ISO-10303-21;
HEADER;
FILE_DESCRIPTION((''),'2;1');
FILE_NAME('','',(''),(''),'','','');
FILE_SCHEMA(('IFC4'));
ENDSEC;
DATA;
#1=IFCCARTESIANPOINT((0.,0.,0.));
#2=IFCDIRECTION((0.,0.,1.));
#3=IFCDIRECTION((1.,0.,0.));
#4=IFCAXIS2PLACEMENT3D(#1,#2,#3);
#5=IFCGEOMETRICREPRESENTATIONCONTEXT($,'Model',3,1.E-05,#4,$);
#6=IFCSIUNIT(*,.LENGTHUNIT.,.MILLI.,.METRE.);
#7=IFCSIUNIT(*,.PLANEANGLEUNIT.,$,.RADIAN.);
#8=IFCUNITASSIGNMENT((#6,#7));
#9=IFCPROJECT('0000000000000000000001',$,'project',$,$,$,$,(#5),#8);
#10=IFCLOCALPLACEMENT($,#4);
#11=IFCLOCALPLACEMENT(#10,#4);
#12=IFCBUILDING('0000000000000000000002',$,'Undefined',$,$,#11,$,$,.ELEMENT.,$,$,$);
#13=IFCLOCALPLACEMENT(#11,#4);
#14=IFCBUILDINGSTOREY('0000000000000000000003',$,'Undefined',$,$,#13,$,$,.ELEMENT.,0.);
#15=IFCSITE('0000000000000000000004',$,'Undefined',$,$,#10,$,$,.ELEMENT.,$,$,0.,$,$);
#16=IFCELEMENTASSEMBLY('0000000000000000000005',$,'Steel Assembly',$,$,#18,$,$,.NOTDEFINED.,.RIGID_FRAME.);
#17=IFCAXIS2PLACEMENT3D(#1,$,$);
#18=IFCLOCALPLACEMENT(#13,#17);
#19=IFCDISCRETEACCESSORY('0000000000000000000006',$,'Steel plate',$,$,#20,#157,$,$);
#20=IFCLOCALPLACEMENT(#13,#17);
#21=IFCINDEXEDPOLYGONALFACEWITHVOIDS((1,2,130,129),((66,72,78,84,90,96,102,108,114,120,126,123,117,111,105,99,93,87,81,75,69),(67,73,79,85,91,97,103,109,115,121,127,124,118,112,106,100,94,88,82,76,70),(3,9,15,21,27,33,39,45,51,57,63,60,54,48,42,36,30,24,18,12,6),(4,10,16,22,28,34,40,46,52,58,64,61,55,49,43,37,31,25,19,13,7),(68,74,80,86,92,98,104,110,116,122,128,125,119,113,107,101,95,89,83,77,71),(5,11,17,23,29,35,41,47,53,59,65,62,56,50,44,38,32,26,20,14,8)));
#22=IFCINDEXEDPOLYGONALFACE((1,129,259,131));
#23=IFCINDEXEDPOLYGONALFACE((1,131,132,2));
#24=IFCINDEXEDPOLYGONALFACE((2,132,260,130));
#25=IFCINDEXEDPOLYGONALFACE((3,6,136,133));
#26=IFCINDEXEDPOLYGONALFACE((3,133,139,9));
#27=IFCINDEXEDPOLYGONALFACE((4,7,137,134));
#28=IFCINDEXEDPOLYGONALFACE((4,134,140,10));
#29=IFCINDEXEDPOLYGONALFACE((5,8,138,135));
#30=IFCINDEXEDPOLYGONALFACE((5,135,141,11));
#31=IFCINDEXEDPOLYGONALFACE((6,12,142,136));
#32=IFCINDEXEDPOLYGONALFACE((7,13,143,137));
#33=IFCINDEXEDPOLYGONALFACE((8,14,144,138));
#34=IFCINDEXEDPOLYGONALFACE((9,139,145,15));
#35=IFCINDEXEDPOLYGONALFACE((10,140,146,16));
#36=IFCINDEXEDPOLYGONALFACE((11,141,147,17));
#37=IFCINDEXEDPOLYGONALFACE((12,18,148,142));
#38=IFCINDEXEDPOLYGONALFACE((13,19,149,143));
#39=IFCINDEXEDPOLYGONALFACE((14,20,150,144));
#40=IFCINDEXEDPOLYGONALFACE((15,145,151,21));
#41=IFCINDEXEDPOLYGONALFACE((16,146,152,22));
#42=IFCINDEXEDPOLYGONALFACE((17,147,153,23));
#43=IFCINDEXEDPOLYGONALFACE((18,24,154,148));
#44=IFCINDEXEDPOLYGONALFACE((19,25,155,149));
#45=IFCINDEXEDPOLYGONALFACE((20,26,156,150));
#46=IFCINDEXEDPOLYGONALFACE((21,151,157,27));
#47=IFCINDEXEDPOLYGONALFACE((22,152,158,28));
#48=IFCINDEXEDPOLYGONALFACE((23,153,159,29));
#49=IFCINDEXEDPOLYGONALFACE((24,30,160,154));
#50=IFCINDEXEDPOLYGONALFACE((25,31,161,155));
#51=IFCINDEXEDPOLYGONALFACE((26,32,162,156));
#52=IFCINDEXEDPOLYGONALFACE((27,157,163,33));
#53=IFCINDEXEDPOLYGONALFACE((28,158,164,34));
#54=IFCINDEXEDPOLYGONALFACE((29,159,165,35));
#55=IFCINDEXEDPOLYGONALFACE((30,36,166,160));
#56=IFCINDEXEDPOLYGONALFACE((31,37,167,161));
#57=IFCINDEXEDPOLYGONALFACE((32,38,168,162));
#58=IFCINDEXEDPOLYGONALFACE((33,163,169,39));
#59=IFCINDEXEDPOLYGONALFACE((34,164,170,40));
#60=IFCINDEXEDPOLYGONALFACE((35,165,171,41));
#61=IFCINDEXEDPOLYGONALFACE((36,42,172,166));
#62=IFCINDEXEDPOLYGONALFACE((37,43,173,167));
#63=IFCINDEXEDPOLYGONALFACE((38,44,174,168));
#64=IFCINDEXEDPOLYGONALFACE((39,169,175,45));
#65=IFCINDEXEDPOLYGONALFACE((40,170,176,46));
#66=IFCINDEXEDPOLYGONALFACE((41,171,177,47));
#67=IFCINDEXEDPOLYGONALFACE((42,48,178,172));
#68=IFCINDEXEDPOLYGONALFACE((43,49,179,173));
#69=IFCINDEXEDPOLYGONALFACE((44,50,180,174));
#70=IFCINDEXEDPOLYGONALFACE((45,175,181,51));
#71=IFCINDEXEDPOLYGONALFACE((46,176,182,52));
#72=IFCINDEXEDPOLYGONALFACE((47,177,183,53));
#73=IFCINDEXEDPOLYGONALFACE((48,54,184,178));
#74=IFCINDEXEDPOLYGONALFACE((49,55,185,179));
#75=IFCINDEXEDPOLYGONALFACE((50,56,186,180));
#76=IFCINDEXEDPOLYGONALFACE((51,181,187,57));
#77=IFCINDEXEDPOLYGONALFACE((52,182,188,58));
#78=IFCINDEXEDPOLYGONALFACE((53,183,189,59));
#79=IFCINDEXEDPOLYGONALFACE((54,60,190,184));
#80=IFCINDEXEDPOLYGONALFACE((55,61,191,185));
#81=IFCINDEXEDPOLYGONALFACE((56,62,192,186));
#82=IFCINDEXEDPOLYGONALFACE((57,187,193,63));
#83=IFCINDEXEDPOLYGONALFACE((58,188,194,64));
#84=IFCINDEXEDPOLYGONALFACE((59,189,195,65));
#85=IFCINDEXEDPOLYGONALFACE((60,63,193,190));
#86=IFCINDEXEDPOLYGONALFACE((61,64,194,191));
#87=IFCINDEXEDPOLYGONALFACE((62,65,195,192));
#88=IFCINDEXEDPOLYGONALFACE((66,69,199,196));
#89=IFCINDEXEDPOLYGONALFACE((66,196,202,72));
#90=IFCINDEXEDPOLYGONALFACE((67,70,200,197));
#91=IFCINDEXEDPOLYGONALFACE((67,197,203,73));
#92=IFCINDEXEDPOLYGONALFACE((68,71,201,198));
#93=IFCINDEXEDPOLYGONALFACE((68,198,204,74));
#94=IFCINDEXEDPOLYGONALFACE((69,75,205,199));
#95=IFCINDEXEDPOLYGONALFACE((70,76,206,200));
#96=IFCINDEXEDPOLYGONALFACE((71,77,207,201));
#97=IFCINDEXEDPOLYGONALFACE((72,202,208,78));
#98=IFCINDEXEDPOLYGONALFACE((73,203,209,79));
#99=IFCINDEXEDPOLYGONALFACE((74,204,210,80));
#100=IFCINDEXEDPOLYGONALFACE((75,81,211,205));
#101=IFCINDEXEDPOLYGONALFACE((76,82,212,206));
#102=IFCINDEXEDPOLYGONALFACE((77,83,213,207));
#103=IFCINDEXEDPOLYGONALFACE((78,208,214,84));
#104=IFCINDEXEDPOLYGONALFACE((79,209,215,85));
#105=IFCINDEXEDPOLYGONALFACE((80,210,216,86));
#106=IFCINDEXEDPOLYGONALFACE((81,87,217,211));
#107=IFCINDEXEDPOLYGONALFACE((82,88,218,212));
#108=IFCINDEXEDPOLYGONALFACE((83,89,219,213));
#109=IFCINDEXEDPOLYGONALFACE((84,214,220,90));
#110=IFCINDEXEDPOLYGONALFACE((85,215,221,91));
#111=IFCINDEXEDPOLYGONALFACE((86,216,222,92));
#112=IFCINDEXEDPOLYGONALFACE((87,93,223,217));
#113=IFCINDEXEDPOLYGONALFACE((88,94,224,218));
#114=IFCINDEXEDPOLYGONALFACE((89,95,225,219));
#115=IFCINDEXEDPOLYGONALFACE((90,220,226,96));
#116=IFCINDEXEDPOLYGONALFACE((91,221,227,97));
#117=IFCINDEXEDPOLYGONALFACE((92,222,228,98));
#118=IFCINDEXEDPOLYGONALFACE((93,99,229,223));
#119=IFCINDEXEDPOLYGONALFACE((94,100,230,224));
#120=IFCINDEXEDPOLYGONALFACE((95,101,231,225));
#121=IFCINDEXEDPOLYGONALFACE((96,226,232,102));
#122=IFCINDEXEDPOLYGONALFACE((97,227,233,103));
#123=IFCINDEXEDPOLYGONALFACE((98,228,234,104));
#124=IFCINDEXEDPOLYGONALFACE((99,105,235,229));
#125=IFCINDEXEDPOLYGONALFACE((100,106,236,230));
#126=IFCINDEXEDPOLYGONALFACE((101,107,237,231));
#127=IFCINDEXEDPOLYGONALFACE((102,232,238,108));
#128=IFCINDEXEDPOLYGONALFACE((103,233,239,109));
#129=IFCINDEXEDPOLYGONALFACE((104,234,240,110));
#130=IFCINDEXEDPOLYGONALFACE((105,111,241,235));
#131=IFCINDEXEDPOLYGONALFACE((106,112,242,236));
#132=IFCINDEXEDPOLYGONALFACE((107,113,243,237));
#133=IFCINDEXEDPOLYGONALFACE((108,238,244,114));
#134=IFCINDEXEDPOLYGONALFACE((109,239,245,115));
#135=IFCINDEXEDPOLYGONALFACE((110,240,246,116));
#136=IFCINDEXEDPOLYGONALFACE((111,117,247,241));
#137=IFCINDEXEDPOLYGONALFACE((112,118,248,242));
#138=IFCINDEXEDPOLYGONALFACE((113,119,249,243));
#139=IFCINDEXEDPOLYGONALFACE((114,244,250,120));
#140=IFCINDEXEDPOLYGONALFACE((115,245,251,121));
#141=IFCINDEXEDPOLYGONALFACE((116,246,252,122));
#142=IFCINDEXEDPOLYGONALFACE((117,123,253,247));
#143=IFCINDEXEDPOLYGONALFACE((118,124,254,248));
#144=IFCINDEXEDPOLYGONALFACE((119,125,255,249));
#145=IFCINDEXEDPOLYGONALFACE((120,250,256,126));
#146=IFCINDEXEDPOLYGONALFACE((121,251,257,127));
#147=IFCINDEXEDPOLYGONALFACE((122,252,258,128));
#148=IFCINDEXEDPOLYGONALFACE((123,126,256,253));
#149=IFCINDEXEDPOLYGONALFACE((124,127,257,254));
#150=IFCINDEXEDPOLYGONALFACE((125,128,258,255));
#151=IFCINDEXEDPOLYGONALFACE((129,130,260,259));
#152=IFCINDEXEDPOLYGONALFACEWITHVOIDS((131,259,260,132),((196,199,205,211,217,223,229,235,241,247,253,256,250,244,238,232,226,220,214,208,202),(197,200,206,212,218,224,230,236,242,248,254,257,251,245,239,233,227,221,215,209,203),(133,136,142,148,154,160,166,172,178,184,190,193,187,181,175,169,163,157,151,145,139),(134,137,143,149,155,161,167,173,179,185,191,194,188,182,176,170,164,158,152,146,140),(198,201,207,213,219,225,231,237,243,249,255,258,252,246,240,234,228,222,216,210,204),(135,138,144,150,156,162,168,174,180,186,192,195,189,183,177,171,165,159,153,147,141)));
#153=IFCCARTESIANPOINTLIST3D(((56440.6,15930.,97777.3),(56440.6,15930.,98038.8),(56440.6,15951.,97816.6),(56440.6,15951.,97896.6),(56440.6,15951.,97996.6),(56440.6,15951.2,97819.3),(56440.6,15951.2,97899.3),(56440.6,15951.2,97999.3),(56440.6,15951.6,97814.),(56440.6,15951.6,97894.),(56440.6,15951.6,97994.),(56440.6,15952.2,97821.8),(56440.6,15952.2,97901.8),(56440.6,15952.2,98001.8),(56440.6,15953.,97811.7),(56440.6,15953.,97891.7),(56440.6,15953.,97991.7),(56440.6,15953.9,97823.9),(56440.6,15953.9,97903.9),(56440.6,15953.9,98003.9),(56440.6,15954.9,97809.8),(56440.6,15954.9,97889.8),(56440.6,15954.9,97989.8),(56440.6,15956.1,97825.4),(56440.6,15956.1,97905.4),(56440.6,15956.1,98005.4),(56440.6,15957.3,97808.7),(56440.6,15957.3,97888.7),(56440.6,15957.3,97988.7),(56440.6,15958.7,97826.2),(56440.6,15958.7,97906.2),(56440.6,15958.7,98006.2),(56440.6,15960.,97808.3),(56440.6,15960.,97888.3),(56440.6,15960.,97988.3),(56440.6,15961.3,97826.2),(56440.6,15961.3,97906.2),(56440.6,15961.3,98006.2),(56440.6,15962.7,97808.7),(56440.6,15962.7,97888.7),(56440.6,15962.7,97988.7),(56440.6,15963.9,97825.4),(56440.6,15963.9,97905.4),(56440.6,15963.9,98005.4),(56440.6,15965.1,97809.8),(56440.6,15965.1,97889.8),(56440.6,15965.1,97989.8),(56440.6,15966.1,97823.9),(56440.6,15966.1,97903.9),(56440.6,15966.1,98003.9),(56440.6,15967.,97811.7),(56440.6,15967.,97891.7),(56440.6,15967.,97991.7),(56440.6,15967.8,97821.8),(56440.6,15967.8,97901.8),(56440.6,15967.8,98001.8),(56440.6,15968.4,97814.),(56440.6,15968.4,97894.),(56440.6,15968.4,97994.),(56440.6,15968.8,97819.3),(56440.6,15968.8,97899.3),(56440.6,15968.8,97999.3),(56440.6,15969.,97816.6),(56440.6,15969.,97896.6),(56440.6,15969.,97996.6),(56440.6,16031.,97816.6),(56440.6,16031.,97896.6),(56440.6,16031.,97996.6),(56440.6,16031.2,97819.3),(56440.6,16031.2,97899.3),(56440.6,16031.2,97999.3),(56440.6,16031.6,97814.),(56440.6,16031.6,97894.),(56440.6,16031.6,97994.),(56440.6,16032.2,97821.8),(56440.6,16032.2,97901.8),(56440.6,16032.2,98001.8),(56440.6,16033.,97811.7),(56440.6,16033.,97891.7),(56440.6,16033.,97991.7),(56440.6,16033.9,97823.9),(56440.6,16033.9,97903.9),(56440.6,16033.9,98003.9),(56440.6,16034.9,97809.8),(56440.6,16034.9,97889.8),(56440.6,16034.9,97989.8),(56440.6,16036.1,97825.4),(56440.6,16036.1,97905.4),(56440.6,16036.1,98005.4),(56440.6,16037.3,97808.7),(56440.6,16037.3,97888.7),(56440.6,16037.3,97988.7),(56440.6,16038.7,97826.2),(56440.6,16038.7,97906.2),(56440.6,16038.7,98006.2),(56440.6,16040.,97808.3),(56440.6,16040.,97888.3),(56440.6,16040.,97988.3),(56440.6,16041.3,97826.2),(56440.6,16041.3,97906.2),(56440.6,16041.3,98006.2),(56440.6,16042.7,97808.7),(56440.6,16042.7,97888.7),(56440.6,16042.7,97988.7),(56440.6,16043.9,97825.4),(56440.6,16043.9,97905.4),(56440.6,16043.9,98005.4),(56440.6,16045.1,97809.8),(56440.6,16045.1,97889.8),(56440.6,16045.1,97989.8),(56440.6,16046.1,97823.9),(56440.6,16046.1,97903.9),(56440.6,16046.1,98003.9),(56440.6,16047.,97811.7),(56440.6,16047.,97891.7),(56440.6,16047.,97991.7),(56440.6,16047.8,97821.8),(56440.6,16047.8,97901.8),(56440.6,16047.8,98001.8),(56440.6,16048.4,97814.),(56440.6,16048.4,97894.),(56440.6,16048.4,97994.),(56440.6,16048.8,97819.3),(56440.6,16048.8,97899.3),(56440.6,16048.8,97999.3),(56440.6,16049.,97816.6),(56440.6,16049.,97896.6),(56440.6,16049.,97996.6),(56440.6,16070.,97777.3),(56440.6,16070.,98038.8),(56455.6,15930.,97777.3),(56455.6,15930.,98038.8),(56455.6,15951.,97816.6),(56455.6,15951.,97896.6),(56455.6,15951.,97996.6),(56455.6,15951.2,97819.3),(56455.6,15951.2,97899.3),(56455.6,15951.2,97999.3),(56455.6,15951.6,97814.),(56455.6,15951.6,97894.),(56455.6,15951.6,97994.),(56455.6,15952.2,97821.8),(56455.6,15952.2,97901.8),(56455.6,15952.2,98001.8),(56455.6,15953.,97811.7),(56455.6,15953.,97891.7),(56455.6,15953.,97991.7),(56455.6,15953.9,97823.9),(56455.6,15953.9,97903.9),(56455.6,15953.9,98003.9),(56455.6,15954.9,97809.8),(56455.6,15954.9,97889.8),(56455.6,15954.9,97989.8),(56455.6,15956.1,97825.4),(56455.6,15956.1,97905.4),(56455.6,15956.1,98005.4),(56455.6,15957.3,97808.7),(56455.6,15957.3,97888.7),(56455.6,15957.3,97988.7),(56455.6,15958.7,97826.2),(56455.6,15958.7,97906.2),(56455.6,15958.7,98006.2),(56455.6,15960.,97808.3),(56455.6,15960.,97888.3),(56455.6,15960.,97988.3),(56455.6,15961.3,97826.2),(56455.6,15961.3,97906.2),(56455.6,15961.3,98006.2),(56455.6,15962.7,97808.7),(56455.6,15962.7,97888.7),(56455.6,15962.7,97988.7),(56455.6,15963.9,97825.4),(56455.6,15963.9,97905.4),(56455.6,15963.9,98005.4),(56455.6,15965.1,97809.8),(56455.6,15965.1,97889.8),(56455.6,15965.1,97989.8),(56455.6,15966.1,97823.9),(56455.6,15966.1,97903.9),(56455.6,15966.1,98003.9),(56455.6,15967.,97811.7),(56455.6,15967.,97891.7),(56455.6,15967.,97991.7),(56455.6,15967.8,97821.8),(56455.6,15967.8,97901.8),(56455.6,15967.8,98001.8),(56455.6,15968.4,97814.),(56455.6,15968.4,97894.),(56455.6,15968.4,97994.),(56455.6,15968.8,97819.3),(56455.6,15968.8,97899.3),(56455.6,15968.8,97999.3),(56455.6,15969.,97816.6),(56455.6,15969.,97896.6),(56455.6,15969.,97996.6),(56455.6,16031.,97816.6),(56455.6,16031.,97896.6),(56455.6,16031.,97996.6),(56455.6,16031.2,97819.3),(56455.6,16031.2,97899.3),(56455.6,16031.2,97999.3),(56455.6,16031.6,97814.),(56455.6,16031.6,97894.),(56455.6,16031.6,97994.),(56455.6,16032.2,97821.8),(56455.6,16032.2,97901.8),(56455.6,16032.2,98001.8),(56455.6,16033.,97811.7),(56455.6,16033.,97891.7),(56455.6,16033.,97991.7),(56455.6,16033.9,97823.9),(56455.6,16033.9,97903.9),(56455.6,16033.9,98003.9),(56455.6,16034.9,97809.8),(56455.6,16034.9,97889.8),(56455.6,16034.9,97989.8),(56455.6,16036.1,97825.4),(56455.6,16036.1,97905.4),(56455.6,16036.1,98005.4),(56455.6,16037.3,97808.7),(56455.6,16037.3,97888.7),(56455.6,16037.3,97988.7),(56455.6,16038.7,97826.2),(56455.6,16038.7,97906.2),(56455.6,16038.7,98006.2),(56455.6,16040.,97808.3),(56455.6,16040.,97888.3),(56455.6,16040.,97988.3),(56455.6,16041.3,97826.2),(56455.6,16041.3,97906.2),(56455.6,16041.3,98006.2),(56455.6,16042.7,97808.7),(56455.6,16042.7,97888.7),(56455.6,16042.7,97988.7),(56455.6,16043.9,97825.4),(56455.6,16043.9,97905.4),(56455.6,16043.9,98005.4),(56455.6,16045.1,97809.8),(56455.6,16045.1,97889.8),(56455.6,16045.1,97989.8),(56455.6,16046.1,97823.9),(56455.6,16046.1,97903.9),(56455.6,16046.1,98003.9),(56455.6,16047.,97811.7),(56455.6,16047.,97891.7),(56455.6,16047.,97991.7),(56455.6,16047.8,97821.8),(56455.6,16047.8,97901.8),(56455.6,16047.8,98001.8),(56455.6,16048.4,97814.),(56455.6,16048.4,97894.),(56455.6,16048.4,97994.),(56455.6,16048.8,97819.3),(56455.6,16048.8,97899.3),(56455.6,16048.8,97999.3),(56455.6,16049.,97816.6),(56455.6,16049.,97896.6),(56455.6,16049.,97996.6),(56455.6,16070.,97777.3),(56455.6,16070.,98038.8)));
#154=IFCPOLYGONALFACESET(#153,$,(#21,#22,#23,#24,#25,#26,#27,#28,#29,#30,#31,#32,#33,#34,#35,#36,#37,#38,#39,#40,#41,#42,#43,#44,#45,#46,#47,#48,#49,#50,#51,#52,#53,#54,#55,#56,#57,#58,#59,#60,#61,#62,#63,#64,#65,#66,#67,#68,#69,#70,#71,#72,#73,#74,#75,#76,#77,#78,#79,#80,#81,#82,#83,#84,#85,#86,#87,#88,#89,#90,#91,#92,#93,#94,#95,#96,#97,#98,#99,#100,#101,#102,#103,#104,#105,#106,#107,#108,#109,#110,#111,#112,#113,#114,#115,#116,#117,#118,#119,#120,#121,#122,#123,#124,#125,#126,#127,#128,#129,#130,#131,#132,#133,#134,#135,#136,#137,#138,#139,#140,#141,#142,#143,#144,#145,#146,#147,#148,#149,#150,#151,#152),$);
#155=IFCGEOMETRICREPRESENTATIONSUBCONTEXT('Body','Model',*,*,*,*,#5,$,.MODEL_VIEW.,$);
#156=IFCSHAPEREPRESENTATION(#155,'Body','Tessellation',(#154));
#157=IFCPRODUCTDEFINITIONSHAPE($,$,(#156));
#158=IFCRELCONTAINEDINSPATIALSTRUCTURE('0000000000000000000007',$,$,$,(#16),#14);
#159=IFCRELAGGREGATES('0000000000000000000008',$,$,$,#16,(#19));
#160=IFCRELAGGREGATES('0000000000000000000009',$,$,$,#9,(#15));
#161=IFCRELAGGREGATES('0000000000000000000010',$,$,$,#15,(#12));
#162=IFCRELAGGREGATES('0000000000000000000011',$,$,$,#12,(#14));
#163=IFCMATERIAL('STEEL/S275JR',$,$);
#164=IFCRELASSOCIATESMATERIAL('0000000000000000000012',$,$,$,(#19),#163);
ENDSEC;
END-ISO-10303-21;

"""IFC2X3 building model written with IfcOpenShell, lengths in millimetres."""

from ifc_helpers import new_model, si_unit, frame, origin_with_axes, origin_2d_with_axis, place, context, subcontext, project, spatial, polyline, circle, outline, extrude, source, transform, mapped, material, element, aggregate, save


model = new_model("IFC2X3")

# Units and contexts
model_context = context("Model", 3, precision=1e-05, world=origin_with_axes())
body_context = subcontext(model_context, "Body", "Model", "MODEL_VIEW")
ifc_project = project(units=[si_unit("LENGTHUNIT", "METRE", prefix="MILLI"), si_unit("PLANEANGLEUNIT", "RADIAN")], contexts=[model_context])

# Site, building, storey
site_placement = place(None, origin_with_axes())
site = spatial("IfcSite", under=ifc_project, at=site_placement, Name="Undefined", CompositionType="ELEMENT", RefElevation=0.0)
building_placement = place(site_placement, origin_with_axes())
building = spatial("IfcBuilding", under=site, at=building_placement, Name="Undefined", CompositionType="ELEMENT")
storey_placement = place(building_placement, origin_with_axes())
storey = spatial("IfcBuildingStorey", under=building, at=storey_placement, Name="Undefined", CompositionType="ELEMENT", Elevation=0.0)

# Shared definitions
ifc_material_1 = material(Name="STEEL/S275JR")

# Element assembly
assembly_1_placement = place(storey_placement, origin_with_axes())
assembly_1 = element("IfcElementAssembly", 1, at=assembly_1_placement, inside=storey, Name="Steel Assembly", AssemblyPlace="NOTDEFINED", PredefinedType="RIGID_FRAME")

# Discrete accessory, opening
discrete_accessory_1_placement = place(assembly_1_placement, frame((56448.1, 15930.0, 98038.8), z_axis=(-1.0, 0.0, 0.0), x_axis=(0.0, 1.0, 0.0)))
discrete_accessory_1 = element("IfcDiscreteAccessory", 2, at=discrete_accessory_1_placement, material=ifc_material_1, Name="Steel plate", context=body_context, shape_type="SweptSolid", body=[
    extrude(outline(polyline([(0.0, 0.0), (140.0, 0.0), (140.0, 261.5), (0.0, 261.5), (0.0, 0.0)])), frame((0.0, 0.0, -7.5), z_axis=(0.0, 0.0, 1.0), x_axis=(1.0, 0.0, 0.0)), (0.0, 0.0, 1.0), 15.0),
])
shared_shape_1 = source(origin_with_axes(), body_context, "Body", "SweptSolid", [
    extrude(circle(Radius=9.0, at=origin_2d_with_axis()), frame((0.0, 0.9, 0.0), z_axis=(0.0, 1.0, 0.0), x_axis=(1.0, 0.0, 0.0)), (0.0, 0.0, 1.0), 16.1),
])
opening_1_placement = place(assembly_1_placement, frame((56439.6, 16000.0, 97997.3), z_axis=(0.0, -1.0, 0.0), x_axis=(0.0, 0.0, -1.0)))
element("IfcOpeningElement", 3, at=opening_1_placement, cuts=discrete_accessory_1, ObjectType="Opening", context=body_context, shape_type="MappedRepresentation", body=[
    mapped(shared_shape_1, transform((0.0, 0.0, -40.0))),
    mapped(shared_shape_1, transform((100.0, 0.0, -40.0))),
    mapped(shared_shape_1, transform((180.0, 0.0, -40.0))),
    mapped(shared_shape_1, transform((0.0, 0.0, 40.0))),
    mapped(shared_shape_1, transform((100.0, 0.0, 40.0))),
    mapped(shared_shape_1, transform((180.0, 0.0, 40.0))),
])
aggregate(assembly_1, [discrete_accessory_1])

save(model, "model.ifc")
